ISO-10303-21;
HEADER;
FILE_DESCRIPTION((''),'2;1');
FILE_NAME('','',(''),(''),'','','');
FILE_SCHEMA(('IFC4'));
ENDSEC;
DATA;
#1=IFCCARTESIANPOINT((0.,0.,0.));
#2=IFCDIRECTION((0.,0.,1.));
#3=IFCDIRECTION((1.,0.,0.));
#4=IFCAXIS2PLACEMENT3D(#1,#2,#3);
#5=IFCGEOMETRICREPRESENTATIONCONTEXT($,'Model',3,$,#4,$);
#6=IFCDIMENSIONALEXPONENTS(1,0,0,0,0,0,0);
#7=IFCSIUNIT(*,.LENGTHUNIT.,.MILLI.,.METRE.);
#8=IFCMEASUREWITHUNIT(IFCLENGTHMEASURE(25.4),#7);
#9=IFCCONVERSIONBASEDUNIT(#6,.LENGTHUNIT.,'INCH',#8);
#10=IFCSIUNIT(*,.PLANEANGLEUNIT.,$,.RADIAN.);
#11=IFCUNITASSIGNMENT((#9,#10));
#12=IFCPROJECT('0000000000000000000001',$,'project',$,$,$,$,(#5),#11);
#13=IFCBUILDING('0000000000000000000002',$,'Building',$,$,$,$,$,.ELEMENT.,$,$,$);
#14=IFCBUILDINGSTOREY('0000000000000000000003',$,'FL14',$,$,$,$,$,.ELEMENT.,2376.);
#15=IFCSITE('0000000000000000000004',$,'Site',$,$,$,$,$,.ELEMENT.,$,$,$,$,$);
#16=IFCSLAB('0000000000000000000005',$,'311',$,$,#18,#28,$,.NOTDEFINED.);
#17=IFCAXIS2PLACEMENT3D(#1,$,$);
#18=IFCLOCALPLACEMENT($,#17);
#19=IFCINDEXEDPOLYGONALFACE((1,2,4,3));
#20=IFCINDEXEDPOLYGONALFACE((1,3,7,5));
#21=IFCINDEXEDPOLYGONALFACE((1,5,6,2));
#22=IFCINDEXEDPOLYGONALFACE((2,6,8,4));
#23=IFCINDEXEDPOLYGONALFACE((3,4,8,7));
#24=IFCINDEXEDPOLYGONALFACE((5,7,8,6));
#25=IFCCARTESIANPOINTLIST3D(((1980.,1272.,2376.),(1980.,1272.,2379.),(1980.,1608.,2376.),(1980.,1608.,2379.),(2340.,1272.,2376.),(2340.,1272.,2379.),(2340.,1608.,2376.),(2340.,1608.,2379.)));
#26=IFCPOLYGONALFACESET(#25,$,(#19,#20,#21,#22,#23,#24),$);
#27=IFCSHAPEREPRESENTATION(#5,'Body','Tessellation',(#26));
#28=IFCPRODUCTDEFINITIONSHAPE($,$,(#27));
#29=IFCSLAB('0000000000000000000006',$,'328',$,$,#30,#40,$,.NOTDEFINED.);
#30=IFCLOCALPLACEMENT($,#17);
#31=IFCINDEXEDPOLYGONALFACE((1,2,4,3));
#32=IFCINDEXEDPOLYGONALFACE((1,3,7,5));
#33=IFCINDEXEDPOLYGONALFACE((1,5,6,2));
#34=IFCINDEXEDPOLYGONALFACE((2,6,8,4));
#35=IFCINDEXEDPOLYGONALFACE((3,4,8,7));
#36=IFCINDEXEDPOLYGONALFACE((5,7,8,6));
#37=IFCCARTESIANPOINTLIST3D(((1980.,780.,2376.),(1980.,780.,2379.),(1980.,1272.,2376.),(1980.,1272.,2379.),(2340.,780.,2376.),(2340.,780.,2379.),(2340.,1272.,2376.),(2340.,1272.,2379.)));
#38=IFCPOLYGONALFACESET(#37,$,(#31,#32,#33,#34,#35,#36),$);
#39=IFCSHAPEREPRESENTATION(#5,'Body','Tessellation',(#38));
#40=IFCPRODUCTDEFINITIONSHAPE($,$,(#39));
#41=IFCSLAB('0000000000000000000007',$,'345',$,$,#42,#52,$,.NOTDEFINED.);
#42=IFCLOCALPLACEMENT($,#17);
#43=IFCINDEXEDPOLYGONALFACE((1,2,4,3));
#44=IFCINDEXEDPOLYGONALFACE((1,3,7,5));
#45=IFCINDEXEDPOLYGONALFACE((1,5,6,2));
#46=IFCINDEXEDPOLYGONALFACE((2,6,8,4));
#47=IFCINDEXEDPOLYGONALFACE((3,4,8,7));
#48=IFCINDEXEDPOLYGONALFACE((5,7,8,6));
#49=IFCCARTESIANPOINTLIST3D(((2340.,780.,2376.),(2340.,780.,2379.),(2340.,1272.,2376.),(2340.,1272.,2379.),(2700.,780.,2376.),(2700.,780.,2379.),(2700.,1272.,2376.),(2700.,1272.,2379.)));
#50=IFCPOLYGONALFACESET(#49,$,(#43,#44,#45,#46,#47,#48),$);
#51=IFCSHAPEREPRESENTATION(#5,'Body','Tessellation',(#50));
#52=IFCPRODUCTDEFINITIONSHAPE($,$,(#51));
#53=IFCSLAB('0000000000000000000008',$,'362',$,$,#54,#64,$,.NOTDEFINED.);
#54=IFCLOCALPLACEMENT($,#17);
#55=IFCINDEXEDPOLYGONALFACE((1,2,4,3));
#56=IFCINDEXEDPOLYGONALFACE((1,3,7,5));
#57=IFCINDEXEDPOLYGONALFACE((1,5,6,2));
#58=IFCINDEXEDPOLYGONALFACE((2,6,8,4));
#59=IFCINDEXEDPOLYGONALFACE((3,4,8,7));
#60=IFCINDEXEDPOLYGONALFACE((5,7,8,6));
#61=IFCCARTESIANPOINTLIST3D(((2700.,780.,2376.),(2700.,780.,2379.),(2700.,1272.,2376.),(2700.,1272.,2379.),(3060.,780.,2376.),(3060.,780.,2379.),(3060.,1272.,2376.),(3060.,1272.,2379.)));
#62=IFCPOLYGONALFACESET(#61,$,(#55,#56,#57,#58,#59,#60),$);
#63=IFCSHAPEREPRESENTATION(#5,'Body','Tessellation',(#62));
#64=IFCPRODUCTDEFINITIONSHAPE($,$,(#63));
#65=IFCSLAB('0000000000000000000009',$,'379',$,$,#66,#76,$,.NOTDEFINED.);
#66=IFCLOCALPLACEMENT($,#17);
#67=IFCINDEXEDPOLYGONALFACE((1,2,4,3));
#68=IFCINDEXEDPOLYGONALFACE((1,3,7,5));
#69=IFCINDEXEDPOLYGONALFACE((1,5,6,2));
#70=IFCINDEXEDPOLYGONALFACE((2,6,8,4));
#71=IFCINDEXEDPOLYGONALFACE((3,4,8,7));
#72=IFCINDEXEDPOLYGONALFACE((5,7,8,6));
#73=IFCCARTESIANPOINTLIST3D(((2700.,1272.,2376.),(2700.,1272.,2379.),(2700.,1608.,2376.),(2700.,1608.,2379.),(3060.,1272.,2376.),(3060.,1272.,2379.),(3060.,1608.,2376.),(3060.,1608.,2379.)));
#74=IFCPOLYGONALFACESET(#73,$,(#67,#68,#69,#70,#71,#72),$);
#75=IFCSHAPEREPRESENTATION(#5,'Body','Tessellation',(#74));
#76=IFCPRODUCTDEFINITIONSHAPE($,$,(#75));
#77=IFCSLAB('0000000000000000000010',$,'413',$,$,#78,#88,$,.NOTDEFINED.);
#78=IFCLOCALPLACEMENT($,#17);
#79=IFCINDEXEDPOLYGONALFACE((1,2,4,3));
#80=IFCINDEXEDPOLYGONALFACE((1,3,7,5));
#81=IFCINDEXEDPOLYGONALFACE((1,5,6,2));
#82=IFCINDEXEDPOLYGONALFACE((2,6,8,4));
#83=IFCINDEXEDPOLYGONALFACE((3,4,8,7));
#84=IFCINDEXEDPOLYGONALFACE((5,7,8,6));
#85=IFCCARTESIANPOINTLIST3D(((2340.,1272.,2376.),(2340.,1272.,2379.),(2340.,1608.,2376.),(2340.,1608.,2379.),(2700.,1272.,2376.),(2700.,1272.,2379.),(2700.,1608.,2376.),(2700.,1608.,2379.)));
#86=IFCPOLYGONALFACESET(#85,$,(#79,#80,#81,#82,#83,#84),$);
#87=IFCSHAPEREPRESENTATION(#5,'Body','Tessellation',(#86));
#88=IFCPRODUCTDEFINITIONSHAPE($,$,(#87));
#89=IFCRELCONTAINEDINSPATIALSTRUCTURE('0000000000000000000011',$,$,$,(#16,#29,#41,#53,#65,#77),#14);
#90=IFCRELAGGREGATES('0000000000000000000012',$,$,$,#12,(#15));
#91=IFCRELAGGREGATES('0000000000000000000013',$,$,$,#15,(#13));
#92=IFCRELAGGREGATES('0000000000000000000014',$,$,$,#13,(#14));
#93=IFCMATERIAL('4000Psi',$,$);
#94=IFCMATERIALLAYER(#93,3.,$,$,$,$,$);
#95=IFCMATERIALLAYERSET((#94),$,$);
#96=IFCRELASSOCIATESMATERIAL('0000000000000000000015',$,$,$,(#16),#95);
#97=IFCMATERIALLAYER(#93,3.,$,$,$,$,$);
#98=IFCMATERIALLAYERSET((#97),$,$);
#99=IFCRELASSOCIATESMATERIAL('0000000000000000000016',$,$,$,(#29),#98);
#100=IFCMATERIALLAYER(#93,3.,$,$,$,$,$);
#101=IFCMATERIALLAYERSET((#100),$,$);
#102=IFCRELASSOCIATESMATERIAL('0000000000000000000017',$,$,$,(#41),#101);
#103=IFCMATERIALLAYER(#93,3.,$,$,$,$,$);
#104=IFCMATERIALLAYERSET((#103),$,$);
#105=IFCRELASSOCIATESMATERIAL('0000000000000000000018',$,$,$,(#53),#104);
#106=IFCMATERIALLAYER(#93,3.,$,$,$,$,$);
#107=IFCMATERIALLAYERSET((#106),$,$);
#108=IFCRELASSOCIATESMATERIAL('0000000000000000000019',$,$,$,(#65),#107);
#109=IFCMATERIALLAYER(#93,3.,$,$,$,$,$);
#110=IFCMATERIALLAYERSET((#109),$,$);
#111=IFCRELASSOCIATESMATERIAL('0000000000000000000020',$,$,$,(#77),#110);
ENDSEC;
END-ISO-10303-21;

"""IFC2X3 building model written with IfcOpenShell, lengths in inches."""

from ifc_helpers import new_model, entity, si_unit, converted_unit, frame, origin_with_axes, place, context, project, spatial, polyline, outline, extrude, material, layer, layer_set, layer_usage, element, save


model = new_model("IFC2X3")

# Units and contexts
model_context = context("Model", 3, world=origin_with_axes())
ifc_project = project(units=[converted_unit("LENGTHUNIT", "INCH", entity("IfcLengthMeasure", 25.4), si_unit("LENGTHUNIT", "METRE", prefix="MILLI"), dimensions=[1, 0, 0, 0, 0, 0, 0]), si_unit("PLANEANGLEUNIT", "RADIAN")], contexts=[model_context])

# Site, building, storey
site = spatial("IfcSite", under=ifc_project, Name="Site", CompositionType="ELEMENT")
building = spatial("IfcBuilding", under=site, Name="Building", CompositionType="ELEMENT")
storey = spatial("IfcBuildingStorey", under=building, Name="FL14", CompositionType="ELEMENT", Elevation=2376.0)

# Slabs
ifc_material_1 = material(Name="4000Psi")
ifc_layer_1 = layer(ifc_material_1, 3.0)
ifc_layer_set_1 = layer_set([ifc_layer_1])
ifc_layer_usage_1 = layer_usage(ifc_layer_set_1, "AXIS2", "POSITIVE", -3.0)
slab_1_placement = place(None, frame((1980.0, 1272.0, 2376.0), z_axis=(0.0, 0.0, 1.0), x_axis=(1.0, 0.0, 0.0)))
element("IfcSlab", 1, at=slab_1_placement, inside=storey, material=ifc_layer_usage_1, Name="311", PredefinedType="NOTDEFINED", context=model_context, shape_type="SweptSolid", body=[
    extrude(outline(polyline([(0.0, 0.0), (360.0, 0.0), (360.0, 336.0), (0.0, 336.0), (0.0, 0.0)])), origin_with_axes(), (0.0, 0.0, 1.0), 3.0),
])
ifc_layer_2 = layer(ifc_material_1, 3.0)
ifc_layer_set_2 = layer_set([ifc_layer_2])
ifc_layer_usage_2 = layer_usage(ifc_layer_set_2, "AXIS2", "POSITIVE", -3.0)
slab_2_placement = place(None, frame((1980.0, 780.0, 2376.0), z_axis=(0.0, 0.0, 1.0), x_axis=(1.0, 0.0, 0.0)))
element("IfcSlab", 2, at=slab_2_placement, inside=storey, material=ifc_layer_usage_2, Name="328", PredefinedType="NOTDEFINED", context=model_context, shape_type="SweptSolid", body=[
    extrude(outline(polyline([(0.0, 0.0), (360.0, 0.0), (360.0, 492.0), (0.0, 492.0), (0.0, 0.0)])), origin_with_axes(), (0.0, 0.0, 1.0), 3.0),
])
ifc_layer_3 = layer(ifc_material_1, 3.0)
ifc_layer_set_3 = layer_set([ifc_layer_3])
ifc_layer_usage_3 = layer_usage(ifc_layer_set_3, "AXIS2", "POSITIVE", -3.0)
slab_3_placement = place(None, frame((2340.0, 780.0, 2376.0), z_axis=(0.0, 0.0, 1.0), x_axis=(1.0, 0.0, 0.0)))
element("IfcSlab", 3, at=slab_3_placement, inside=storey, material=ifc_layer_usage_3, Name="345", PredefinedType="NOTDEFINED", context=model_context, shape_type="SweptSolid", body=[
    extrude(outline(polyline([(0.0, 0.0), (360.0, 0.0), (360.0, 492.0), (0.0, 492.0), (0.0, 0.0)])), origin_with_axes(), (0.0, 0.0, 1.0), 3.0),
])
ifc_layer_4 = layer(ifc_material_1, 3.0)
ifc_layer_set_4 = layer_set([ifc_layer_4])
ifc_layer_usage_4 = layer_usage(ifc_layer_set_4, "AXIS2", "POSITIVE", -3.0)
slab_4_placement = place(None, frame((2700.0, 780.0, 2376.0), z_axis=(0.0, 0.0, 1.0), x_axis=(1.0, 0.0, 0.0)))
element("IfcSlab", 4, at=slab_4_placement, inside=storey, material=ifc_layer_usage_4, Name="362", PredefinedType="NOTDEFINED", context=model_context, shape_type="SweptSolid", body=[
    extrude(outline(polyline([(0.0, 0.0), (360.0, 0.0), (360.0, 492.0), (0.0, 492.0), (0.0, 0.0)])), origin_with_axes(), (0.0, 0.0, 1.0), 3.0),
])
ifc_layer_5 = layer(ifc_material_1, 3.0)
ifc_layer_set_5 = layer_set([ifc_layer_5])
ifc_layer_usage_5 = layer_usage(ifc_layer_set_5, "AXIS2", "POSITIVE", -3.0)
slab_5_placement = place(None, frame((2700.0, 1272.0, 2376.0), z_axis=(0.0, 0.0, 1.0), x_axis=(1.0, 0.0, 0.0)))
element("IfcSlab", 5, at=slab_5_placement, inside=storey, material=ifc_layer_usage_5, Name="379", PredefinedType="NOTDEFINED", context=model_context, shape_type="SweptSolid", body=[
    extrude(outline(polyline([(0.0, 0.0), (360.0, 0.0), (360.0, 336.0), (0.0, 336.0), (0.0, 0.0)])), origin_with_axes(), (0.0, 0.0, 1.0), 3.0),
])
ifc_layer_6 = layer(ifc_material_1, 3.0)
ifc_layer_set_6 = layer_set([ifc_layer_6])
ifc_layer_usage_6 = layer_usage(ifc_layer_set_6, "AXIS2", "POSITIVE", -3.0)
slab_6_placement = place(None, frame((2340.0, 1272.0, 2376.0), z_axis=(0.0, 0.0, 1.0), x_axis=(1.0, 0.0, 0.0)))
element("IfcSlab", 6, at=slab_6_placement, inside=storey, material=ifc_layer_usage_6, Name="413", PredefinedType="NOTDEFINED", context=model_context, shape_type="SweptSolid", body=[
    extrude(outline(polyline([(0.0, 0.0), (360.0, 0.0), (360.0, 336.0), (0.0, 336.0), (0.0, 0.0)])), origin_with_axes(), (0.0, 0.0, 1.0), 3.0),
])

save(model, "model.ifc")
